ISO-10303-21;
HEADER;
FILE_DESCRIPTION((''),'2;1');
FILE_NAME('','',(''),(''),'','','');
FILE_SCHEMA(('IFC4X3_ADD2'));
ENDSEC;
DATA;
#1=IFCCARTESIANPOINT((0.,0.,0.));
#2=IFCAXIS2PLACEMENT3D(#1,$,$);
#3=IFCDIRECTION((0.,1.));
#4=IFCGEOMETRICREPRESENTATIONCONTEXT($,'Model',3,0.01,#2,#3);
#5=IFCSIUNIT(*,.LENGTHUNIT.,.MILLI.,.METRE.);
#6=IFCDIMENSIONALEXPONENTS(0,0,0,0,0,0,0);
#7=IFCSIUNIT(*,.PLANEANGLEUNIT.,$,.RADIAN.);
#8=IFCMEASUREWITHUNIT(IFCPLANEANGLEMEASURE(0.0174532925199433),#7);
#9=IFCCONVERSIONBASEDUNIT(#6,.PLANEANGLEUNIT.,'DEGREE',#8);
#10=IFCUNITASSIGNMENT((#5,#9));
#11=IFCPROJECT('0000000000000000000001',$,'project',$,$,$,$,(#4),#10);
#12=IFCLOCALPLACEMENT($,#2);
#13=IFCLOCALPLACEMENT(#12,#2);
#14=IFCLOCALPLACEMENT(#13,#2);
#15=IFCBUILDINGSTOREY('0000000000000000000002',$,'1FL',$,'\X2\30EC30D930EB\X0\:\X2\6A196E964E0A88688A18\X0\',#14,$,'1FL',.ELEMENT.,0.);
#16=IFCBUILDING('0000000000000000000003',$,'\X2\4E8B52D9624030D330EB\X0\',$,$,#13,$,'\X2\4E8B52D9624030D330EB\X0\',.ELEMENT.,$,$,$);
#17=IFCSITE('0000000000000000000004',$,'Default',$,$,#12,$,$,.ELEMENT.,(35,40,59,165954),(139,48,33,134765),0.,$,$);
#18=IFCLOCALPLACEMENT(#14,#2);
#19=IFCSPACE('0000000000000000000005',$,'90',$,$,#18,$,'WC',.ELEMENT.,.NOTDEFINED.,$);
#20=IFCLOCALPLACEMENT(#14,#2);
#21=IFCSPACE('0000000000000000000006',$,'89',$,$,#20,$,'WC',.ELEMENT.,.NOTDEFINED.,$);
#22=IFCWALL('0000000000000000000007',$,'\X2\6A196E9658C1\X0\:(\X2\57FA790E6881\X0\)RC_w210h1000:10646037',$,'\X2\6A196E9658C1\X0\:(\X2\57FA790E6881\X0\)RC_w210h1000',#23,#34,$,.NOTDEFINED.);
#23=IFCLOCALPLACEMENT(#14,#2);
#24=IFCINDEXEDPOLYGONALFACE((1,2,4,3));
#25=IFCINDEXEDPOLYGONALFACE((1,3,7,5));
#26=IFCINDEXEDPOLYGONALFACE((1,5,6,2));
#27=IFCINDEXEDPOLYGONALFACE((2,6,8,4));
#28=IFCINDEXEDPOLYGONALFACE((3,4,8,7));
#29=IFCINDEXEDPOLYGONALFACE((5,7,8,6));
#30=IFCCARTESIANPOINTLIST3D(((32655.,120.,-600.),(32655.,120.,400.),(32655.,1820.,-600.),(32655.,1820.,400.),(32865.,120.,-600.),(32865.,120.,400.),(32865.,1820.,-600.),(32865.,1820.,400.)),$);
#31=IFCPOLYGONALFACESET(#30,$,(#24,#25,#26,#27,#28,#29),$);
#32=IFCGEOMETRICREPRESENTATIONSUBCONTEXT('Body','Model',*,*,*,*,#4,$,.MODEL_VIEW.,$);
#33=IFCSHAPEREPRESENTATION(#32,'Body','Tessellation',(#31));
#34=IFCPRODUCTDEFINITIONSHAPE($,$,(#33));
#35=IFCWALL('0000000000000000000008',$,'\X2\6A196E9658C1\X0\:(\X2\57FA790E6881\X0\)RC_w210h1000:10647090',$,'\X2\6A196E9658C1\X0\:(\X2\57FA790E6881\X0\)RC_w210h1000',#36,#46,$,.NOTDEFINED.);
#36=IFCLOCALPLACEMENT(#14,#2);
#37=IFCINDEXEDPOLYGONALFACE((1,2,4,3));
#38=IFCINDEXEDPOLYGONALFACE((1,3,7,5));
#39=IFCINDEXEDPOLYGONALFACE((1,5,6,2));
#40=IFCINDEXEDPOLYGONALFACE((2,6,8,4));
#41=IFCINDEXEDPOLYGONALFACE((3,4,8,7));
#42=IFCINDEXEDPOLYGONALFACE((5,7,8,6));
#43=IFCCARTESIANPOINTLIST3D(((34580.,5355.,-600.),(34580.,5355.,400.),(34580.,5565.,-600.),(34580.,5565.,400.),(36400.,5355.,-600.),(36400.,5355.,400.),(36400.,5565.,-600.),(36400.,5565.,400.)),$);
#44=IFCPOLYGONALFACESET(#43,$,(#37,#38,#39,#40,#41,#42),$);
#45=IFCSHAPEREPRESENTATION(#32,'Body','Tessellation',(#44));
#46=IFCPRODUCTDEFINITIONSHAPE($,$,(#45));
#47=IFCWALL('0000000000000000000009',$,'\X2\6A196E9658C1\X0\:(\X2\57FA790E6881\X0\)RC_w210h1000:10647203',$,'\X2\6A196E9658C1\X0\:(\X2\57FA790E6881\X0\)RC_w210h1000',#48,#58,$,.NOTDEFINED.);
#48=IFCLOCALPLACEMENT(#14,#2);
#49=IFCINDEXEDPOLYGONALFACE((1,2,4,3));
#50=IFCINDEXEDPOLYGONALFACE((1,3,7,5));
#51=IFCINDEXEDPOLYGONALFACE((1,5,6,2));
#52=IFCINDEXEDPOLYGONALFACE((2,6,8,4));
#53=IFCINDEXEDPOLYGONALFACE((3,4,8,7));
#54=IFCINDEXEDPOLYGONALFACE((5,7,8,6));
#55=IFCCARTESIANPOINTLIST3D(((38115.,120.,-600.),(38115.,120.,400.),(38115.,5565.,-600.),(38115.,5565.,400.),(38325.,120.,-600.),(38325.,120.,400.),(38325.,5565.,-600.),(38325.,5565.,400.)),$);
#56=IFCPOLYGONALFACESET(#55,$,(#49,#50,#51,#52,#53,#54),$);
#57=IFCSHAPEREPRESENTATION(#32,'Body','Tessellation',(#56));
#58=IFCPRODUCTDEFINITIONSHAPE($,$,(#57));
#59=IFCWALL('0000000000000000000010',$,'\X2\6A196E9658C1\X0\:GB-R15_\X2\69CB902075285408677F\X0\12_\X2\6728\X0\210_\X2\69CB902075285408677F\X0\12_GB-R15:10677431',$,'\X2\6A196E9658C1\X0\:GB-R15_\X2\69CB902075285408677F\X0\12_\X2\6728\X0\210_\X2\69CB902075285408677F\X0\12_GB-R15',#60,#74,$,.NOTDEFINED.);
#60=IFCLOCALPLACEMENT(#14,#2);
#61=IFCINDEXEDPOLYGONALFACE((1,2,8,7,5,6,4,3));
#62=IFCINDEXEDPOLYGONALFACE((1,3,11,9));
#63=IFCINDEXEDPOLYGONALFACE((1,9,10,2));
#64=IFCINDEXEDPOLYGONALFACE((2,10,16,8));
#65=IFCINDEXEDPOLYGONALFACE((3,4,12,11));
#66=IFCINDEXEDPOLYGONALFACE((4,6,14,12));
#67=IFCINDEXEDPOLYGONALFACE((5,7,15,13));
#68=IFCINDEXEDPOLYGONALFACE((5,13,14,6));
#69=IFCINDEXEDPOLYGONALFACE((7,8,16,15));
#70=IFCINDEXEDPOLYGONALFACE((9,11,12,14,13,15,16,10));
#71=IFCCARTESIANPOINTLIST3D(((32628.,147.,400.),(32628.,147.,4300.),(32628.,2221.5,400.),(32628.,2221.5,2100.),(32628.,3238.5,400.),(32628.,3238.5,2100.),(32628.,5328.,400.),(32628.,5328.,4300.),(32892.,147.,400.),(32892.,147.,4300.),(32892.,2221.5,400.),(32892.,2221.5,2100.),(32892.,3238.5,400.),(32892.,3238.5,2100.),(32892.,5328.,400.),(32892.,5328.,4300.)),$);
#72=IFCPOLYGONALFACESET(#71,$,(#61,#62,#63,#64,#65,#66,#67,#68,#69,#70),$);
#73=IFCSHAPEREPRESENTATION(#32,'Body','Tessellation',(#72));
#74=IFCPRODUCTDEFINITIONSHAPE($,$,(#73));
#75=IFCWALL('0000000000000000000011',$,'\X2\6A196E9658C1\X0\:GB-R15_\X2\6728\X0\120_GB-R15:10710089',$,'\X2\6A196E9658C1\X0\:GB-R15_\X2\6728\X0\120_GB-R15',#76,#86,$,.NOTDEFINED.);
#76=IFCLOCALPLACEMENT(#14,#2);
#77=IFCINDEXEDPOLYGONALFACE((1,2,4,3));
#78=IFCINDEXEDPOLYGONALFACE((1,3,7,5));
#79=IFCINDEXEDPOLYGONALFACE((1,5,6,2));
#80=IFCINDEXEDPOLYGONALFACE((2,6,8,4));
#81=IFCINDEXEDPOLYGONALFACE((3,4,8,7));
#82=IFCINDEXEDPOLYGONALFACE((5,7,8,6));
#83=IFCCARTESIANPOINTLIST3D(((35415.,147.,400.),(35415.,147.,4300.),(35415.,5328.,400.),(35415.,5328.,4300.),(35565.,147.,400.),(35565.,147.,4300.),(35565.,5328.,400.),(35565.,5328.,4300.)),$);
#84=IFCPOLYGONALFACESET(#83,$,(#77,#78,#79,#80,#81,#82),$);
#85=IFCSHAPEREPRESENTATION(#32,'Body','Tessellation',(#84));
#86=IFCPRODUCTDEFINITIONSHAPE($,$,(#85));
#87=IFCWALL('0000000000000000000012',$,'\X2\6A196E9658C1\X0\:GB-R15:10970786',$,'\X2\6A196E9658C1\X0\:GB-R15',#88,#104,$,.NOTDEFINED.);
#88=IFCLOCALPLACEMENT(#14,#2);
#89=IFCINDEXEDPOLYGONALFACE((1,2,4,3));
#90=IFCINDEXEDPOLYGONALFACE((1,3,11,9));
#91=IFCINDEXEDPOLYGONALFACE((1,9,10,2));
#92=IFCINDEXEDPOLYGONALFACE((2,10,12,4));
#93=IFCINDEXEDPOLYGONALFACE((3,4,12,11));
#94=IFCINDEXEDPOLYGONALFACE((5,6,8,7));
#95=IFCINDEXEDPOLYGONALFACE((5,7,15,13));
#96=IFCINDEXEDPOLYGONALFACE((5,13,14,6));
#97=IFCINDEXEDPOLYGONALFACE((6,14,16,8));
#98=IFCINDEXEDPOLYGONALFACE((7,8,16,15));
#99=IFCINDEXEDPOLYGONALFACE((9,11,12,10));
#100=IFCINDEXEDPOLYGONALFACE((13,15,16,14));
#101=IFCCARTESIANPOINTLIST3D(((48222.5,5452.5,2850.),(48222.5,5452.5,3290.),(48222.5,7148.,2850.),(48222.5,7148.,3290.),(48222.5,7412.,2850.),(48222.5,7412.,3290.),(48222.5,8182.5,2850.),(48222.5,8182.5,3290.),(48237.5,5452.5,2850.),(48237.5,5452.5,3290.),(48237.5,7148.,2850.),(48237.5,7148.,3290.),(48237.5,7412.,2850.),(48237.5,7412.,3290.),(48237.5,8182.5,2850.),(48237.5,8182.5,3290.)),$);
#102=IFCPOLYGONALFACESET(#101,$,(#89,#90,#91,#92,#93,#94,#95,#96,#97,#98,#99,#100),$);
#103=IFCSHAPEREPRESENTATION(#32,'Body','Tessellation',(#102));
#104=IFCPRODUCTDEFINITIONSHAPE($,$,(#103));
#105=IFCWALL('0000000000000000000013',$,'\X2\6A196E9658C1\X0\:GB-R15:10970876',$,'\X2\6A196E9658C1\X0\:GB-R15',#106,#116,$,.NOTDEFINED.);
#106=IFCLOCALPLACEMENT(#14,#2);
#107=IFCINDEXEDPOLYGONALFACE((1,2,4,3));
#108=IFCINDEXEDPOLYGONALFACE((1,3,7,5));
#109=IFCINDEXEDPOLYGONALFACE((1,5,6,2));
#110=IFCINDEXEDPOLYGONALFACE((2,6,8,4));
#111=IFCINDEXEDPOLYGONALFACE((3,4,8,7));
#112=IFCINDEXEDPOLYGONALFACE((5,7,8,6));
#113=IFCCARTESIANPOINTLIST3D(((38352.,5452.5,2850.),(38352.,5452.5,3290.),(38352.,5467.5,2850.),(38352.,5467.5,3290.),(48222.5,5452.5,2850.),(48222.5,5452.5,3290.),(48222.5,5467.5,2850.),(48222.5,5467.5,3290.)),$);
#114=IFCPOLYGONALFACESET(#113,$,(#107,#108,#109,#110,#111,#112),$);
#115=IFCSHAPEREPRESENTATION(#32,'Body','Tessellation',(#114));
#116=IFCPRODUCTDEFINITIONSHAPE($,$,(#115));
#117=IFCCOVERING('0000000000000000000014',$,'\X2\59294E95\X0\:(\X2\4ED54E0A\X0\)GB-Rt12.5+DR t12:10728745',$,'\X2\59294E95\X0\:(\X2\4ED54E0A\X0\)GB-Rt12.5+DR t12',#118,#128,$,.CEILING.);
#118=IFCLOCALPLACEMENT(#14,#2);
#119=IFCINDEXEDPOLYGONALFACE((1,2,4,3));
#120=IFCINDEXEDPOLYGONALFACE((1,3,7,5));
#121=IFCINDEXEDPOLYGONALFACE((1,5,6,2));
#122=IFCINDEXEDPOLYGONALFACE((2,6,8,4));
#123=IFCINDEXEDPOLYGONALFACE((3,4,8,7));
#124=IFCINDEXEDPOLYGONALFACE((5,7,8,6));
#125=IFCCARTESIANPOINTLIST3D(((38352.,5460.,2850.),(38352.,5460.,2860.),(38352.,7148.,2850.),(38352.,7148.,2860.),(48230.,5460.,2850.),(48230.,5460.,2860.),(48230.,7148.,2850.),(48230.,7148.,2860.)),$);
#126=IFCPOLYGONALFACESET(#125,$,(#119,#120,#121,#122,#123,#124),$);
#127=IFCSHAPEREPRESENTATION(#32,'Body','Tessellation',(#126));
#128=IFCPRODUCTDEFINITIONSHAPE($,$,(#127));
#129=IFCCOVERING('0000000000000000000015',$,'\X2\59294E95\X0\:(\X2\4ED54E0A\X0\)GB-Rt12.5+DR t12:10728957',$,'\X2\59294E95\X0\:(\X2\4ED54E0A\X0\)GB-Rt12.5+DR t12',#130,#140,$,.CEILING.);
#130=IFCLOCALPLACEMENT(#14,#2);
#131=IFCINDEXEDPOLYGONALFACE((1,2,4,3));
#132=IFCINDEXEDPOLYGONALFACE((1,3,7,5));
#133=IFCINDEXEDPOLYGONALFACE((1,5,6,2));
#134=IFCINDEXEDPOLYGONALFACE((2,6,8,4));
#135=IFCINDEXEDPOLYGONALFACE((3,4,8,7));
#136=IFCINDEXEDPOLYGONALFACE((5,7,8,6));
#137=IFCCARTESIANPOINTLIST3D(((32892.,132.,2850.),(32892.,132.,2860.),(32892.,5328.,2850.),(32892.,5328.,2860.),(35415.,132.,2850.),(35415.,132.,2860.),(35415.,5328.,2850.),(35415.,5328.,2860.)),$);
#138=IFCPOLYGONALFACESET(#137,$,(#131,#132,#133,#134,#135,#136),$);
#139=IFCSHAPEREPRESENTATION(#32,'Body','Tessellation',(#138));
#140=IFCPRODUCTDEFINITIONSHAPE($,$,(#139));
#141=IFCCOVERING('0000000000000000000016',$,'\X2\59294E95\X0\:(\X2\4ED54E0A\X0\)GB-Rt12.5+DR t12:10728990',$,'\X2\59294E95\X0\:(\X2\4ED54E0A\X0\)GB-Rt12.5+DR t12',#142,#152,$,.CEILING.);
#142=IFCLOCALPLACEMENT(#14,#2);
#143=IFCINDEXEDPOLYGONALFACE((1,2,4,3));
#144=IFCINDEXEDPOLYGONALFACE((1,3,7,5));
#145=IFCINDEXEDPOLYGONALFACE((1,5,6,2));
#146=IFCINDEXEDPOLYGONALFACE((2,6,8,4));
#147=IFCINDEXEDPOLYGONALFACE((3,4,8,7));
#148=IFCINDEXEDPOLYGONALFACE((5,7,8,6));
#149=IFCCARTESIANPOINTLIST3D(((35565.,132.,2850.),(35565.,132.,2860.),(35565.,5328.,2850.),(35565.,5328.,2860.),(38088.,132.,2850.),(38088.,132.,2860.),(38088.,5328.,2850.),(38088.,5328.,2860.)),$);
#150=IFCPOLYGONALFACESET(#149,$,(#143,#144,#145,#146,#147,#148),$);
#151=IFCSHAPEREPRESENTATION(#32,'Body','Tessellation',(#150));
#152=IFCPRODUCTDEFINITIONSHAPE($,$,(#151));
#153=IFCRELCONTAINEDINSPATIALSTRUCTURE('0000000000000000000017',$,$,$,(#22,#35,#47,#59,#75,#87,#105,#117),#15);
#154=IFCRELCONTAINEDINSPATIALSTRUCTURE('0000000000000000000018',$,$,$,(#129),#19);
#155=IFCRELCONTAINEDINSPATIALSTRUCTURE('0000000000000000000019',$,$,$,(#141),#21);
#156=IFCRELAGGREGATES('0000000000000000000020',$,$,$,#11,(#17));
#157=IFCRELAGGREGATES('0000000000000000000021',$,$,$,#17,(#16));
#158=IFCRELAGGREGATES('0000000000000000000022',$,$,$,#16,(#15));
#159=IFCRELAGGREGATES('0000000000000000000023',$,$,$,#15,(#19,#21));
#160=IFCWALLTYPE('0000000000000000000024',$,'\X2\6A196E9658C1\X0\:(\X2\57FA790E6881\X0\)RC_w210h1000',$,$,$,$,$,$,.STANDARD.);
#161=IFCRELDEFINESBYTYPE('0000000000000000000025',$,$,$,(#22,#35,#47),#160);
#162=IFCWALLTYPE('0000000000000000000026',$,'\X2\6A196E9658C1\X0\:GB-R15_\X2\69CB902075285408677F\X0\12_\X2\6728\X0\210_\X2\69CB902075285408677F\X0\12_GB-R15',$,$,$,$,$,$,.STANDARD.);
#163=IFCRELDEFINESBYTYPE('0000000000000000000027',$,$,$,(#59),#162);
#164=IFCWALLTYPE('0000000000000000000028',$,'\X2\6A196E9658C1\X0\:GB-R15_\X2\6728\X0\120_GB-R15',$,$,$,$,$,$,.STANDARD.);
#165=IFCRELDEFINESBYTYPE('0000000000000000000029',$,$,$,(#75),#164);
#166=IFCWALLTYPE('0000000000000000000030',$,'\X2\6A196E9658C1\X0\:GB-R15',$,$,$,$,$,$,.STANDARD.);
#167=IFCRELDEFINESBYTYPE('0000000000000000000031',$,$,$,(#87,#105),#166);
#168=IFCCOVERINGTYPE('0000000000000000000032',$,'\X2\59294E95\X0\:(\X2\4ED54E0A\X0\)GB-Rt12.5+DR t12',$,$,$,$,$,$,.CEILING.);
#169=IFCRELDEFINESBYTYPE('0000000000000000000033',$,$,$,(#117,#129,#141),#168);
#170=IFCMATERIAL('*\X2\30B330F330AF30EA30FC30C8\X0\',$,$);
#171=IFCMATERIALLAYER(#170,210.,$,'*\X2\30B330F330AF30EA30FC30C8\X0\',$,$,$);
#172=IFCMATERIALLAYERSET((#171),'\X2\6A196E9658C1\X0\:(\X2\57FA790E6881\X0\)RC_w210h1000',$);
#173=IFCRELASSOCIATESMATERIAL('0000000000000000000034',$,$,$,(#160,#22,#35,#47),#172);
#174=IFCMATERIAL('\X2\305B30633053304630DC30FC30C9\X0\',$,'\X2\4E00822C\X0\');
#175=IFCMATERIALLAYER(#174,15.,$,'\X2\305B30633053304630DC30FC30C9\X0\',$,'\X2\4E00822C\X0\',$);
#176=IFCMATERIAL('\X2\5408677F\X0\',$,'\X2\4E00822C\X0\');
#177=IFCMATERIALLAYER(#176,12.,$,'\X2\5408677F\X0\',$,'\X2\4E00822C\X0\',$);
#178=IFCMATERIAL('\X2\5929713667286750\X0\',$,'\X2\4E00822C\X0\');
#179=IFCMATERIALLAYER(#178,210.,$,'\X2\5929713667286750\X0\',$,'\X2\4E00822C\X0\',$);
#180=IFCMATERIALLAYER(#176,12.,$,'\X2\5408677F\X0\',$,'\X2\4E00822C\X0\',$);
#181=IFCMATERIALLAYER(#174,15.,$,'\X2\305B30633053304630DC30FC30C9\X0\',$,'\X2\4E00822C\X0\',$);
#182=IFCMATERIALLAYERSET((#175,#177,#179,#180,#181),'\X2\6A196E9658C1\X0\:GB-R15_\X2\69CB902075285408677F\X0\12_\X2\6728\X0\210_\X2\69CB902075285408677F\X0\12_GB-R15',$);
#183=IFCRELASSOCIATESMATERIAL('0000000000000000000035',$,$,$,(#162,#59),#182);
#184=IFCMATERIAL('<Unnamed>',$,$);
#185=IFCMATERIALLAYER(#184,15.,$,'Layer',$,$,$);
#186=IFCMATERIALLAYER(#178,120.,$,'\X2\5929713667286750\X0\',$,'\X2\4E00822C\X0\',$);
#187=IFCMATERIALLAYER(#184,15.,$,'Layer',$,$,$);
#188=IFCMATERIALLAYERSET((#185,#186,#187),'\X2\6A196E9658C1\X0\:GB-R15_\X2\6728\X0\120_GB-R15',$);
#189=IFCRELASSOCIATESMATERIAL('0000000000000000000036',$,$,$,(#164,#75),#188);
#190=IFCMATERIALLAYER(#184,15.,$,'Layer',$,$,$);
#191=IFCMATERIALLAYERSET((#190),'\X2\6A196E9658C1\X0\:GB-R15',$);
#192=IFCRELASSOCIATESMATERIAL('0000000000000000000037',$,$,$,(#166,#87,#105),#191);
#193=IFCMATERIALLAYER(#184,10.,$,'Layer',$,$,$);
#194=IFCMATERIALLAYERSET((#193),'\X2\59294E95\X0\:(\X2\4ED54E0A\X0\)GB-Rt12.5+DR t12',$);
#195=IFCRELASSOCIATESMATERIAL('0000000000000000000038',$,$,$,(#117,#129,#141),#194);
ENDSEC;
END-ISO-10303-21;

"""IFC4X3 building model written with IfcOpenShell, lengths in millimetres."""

from ifc_helpers import new_model, entity, si_unit, converted_unit, direction, frame, frame_2d, origin, origin_2d_with_axis, place, context, subcontext, project, spatial, rectangle, extrude, material, layer, layer_set, layer_usage, type_object, element, save


model = new_model("IFC4X3")

# Units and contexts
model_context = context("Model", 3, precision=0.01, world=origin(), true_north=direction((0.0, 1.0)))
body_context = subcontext(model_context, "Body", "Model", "MODEL_VIEW")
ifc_project = project(units=[si_unit("LENGTHUNIT", "METRE", prefix="MILLI"), converted_unit("PLANEANGLEUNIT", "DEGREE", entity("IfcPlaneAngleMeasure", 0.0174532925199433), si_unit("PLANEANGLEUNIT", "RADIAN"), dimensions=[0, 0, 0, 0, 0, 0, 0])], contexts=[model_context])

# Site, building, storey
site_placement = place(None, origin())
site = spatial("IfcSite", under=ifc_project, at=site_placement, Name="Default", CompositionType="ELEMENT", RefLatitude=(35, 40, 59, 165954), RefLongitude=(139, 48, 33, 134765), RefElevation=0.0)
building_placement = place(site_placement, origin())
building = spatial("IfcBuilding", under=site, at=building_placement, Name="事務所ビル", LongName="事務所ビル", CompositionType="ELEMENT")
storey_placement = place(building_placement, origin())
storey = spatial("IfcBuildingStorey", under=building, at=storey_placement, Name="1FL", ObjectType="レベル:標準上表記", LongName="1FL", CompositionType="ELEMENT", Elevation=0.0)

# Shared definitions
ifc_material_1 = material(Name="*コンクリート")

# Walls
ifc_layer_1 = layer(ifc_material_1, 210.0, Name="*コンクリート")
ifc_layer_set_1 = layer_set([ifc_layer_1], Name="標準壁:(基礎梁)RC_w210h1000")
wall_type_1 = type_object("IfcWallType", Name="標準壁:(基礎梁)RC_w210h1000", PredefinedType="STANDARD", material=ifc_layer_set_1)
wall_1_placement = place(storey_placement, frame((32760.0, 120.0, -600.0), z_axis=(0.0, 0.0, 1.0), x_axis=(0.0, 1.0, 0.0)))
element("IfcWall", 1, at=wall_1_placement, inside=storey, type_object=wall_type_1, material=ifc_layer_set_1, Name="標準壁:(基礎梁)RC_w210h1000:10646037", ObjectType="標準壁:(基礎梁)RC_w210h1000", PredefinedType="NOTDEFINED", context=body_context, shape_type="SweptSolid", body=[
    extrude(rectangle(XDim=1700.0, YDim=210.0, at=frame_2d((850.0, 0.0), x_axis=(-1.0, 0.0))), origin(), (0.0, 0.0, 1.0), 1000.0),
])
wall_2_placement = place(storey_placement, frame((34580.0, 5460.0, -600.0)))
element("IfcWall", 2, at=wall_2_placement, inside=storey, type_object=wall_type_1, material=ifc_layer_set_1, Name="標準壁:(基礎梁)RC_w210h1000:10647090", ObjectType="標準壁:(基礎梁)RC_w210h1000", PredefinedType="NOTDEFINED", context=body_context, shape_type="SweptSolid", body=[
    extrude(rectangle(XDim=1820.0, YDim=210.0, at=frame_2d((910.0, 0.0), x_axis=(-1.0, 0.0))), origin(), (0.0, 0.0, 1.0), 1000.0),
])
wall_3_placement = place(storey_placement, frame((38220.0, 120.0, -600.0), z_axis=(0.0, 0.0, 1.0), x_axis=(0.0, 1.0, 0.0)))
element("IfcWall", 3, at=wall_3_placement, inside=storey, type_object=wall_type_1, material=ifc_layer_set_1, Name="標準壁:(基礎梁)RC_w210h1000:10647203", ObjectType="標準壁:(基礎梁)RC_w210h1000", PredefinedType="NOTDEFINED", context=body_context, shape_type="SweptSolid", body=[
    extrude(rectangle(XDim=5445.0, YDim=210.0, at=frame_2d((2722.5, 0.0), x_axis=(-1.0, 0.0))), origin(), (0.0, 0.0, 1.0), 1000.0),
])

# Shared definitions
ifc_material_2 = material(Name="せっこうボード", Category="一般")
ifc_layer_2 = layer(ifc_material_2, 15.0, Name="せっこうボード", Category="一般")
ifc_material_3 = material(Name="合板", Category="一般")
ifc_layer_3 = layer(ifc_material_3, 12.0, Name="合板", Category="一般")
ifc_material_4 = material(Name="天然木材", Category="一般")
ifc_layer_4 = layer(ifc_material_4, 210.0, Name="天然木材", Category="一般")
ifc_layer_5 = layer(ifc_material_3, 12.0, Name="合板", Category="一般")
ifc_layer_6 = layer(ifc_material_2, 15.0, Name="せっこうボード", Category="一般")
ifc_layer_set_2 = layer_set([ifc_layer_2, ifc_layer_3, ifc_layer_4, ifc_layer_5, ifc_layer_6], Name="標準壁:GB-R15_構造用合板12_木210_構造用合板12_GB-R15")
wall_type_2 = type_object("IfcWallType", Name="標準壁:GB-R15_構造用合板12_木210_構造用合板12_GB-R15", PredefinedType="STANDARD", material=ifc_layer_set_2)

# Wall, opening
wall_4_placement = place(storey_placement, frame((32760.0, 147.0, 400.0), z_axis=(0.0, 0.0, 1.0), x_axis=(0.0, 1.0, 0.0)))
wall_4 = element("IfcWall", 4, at=wall_4_placement, inside=storey, type_object=wall_type_2, material=ifc_layer_set_2, Name="標準壁:GB-R15_構造用合板12_木210_構造用合板12_GB-R15:10677431", ObjectType="標準壁:GB-R15_構造用合板12_木210_構造用合板12_GB-R15", PredefinedType="NOTDEFINED", context=body_context, shape_type="SweptSolid", body=[
    extrude(rectangle(XDim=5181.0, YDim=264.0, at=frame_2d((2590.5, 0.0), x_axis=(1.0, 0.0))), origin(), (0.0, 0.0, 1.0), 3900.0),
])
opening_1_placement = place(wall_4_placement, frame((2074.5, -132.0, -400.0)))
element("IfcOpeningElement", 5, at=opening_1_placement, cuts=wall_4, PredefinedType="OPENING", context=body_context, shape_type="SweptSolid", body=[
    extrude(rectangle(XDim=2100.0, YDim=1017.0, at=frame_2d((1050.0, 508.5), x_axis=(-1.0, 0.0))), frame((0.0, 0.0, 0.0), z_axis=(0.0, 1.0, 0.0), x_axis=(0.0, 0.0, 1.0)), (0.0, 0.0, 1.0), 264.0),
])

# Wall
ifc_material_5 = material(Name="<Unnamed>")
ifc_layer_7 = layer(ifc_material_5, 15.0, Name="Layer")
ifc_layer_8 = layer(ifc_material_4, 120.0, Name="天然木材", Category="一般")
ifc_layer_9 = layer(ifc_material_5, 15.0, Name="Layer")
ifc_layer_set_3 = layer_set([ifc_layer_7, ifc_layer_8, ifc_layer_9], Name="標準壁:GB-R15_木120_GB-R15")
wall_type_3 = type_object("IfcWallType", Name="標準壁:GB-R15_木120_GB-R15", PredefinedType="STANDARD", material=ifc_layer_set_3)
wall_5_placement = place(storey_placement, frame((35490.0, 147.0, 400.0), z_axis=(0.0, 0.0, 1.0), x_axis=(0.0, 1.0, 0.0)))
element("IfcWall", 6, at=wall_5_placement, inside=storey, type_object=wall_type_3, material=ifc_layer_set_3, Name="標準壁:GB-R15_木120_GB-R15:10710089", ObjectType="標準壁:GB-R15_木120_GB-R15", PredefinedType="NOTDEFINED", context=body_context, shape_type="SweptSolid", body=[
    extrude(rectangle(XDim=5181.0, YDim=150.0, at=frame_2d((2590.5, 0.0), x_axis=(-1.0, 0.0))), origin(), (0.0, 0.0, 1.0), 3900.0),
])

# Wall, opening
ifc_layer_10 = layer(ifc_material_5, 15.0, Name="Layer")
ifc_layer_set_4 = layer_set([ifc_layer_10], Name="標準壁:GB-R15")
wall_type_4 = type_object("IfcWallType", Name="標準壁:GB-R15", PredefinedType="STANDARD", material=ifc_layer_set_4)
wall_6_placement = place(storey_placement, frame((48230.0, 8182.5, 2850.0), z_axis=(0.0, 0.0, 1.0), x_axis=(0.0, -1.0, 0.0)))
wall_6 = element("IfcWall", 7, at=wall_6_placement, inside=storey, type_object=wall_type_4, material=ifc_layer_set_4, Name="標準壁:GB-R15:10970786", ObjectType="標準壁:GB-R15", PredefinedType="NOTDEFINED", context=body_context, shape_type="SweptSolid", body=[
    extrude(rectangle(XDim=2730.0, YDim=15.0, at=frame_2d((1365.0, 0.0), x_axis=(-1.0, 0.0))), origin(), (0.0, 0.0, 1.0), 440.0),
])
opening_2_placement = place(storey_placement, frame((48230.0, 8182.5, 2850.0), z_axis=(0.0, 0.0, 1.0), x_axis=(0.0, -1.0, 0.0)))
element("IfcOpeningElement", 8, at=opening_2_placement, cuts=wall_6, PredefinedType="OPENING", context=body_context, shape_type="SweptSolid", body=[
    extrude(rectangle(XDim=440.0, YDim=15.0, at=frame_2d((0.0, 0.0), x_axis=(1.0, 0.0))), frame((1034.5, 0.0, 220.0), z_axis=(-1.0, 0.0, 0.0), x_axis=(0.0, 0.0, 1.0)), (0.0, 0.0, 1.0), 264.0),
])

# Wall
wall_7_placement = place(storey_placement, frame((48222.5, 5460.0, 2850.0), z_axis=(0.0, 0.0, 1.0), x_axis=(-1.0, 0.0, 0.0)))
element("IfcWall", 9, at=wall_7_placement, inside=storey, type_object=wall_type_4, material=ifc_layer_set_4, Name="標準壁:GB-R15:10970876", ObjectType="標準壁:GB-R15", PredefinedType="NOTDEFINED", context=body_context, shape_type="SweptSolid", body=[
    extrude(rectangle(XDim=9870.5, YDim=15.0, at=frame_2d((4935.2, 0.0), x_axis=(-1.0, 0.0))), origin(), (0.0, 0.0, 1.0), 440.0),
])

# Covering
ifc_layer_11 = layer(ifc_material_5, 10.0, Name="Layer")
ifc_layer_set_5 = layer_set([ifc_layer_11], Name="天井:(仕上)GB-Rt12.5+DR t12")
covering_type = type_object("IfcCoveringType", Name="天井:(仕上)GB-Rt12.5+DR t12", PredefinedType="CEILING")
ifc_layer_usage_1 = layer_usage(ifc_layer_set_5, "AXIS3", "NEGATIVE", 0.0)
covering_1_placement = place(storey_placement, frame((38352.0, 5460.0, 2850.0)))
element("IfcCovering", 10, at=covering_1_placement, inside=storey, type_object=covering_type, material=ifc_layer_usage_1, Name="天井:(仕上)GB-Rt12.5+DR t12:10728745", ObjectType="天井:(仕上)GB-Rt12.5+DR t12", PredefinedType="CEILING", context=body_context, shape_type="SweptSolid", body=[
    extrude(rectangle(XDim=9878.0, YDim=1688.0, at=origin_2d_with_axis()), frame((4939.0, 844.0, 0.0)), (0.0, 0.0, 1.0), 10.0),
])

# Shared definitions
space_1_placement = place(storey_placement, origin())
space_1 = spatial("IfcSpace", under=storey, at=space_1_placement, Name="90", LongName="WC", CompositionType="ELEMENT", PredefinedType="NOTDEFINED")

# Covering
ifc_layer_usage_2 = layer_usage(ifc_layer_set_5, "AXIS3", "NEGATIVE", 0.0)
covering_2_placement = place(space_1_placement, frame((32892.0, 132.0, 2850.0)))
element("IfcCovering", 11, at=covering_2_placement, inside=space_1, type_object=covering_type, material=ifc_layer_usage_2, Name="天井:(仕上)GB-Rt12.5+DR t12:10728957", ObjectType="天井:(仕上)GB-Rt12.5+DR t12", PredefinedType="CEILING", context=body_context, shape_type="SweptSolid", body=[
    extrude(rectangle(XDim=2523.0, YDim=5196.0, at=frame_2d((0.0, 0.0), x_axis=(1.0, 0.0))), frame((1261.5, 2598.0, 0.0), z_axis=(0.0, 0.0, 1.0), x_axis=(-1.0, 0.0, 0.0)), (0.0, 0.0, 1.0), 10.0),
])

# Shared definitions
space_2_placement = place(storey_placement, origin())
space_2 = spatial("IfcSpace", under=storey, at=space_2_placement, Name="89", LongName="WC", CompositionType="ELEMENT", PredefinedType="NOTDEFINED")

# Covering
ifc_layer_usage_3 = layer_usage(ifc_layer_set_5, "AXIS3", "NEGATIVE", 0.0)
covering_3_placement = place(space_2_placement, frame((35565.0, 132.0, 2850.0)))
element("IfcCovering", 12, at=covering_3_placement, inside=space_2, type_object=covering_type, material=ifc_layer_usage_3, Name="天井:(仕上)GB-Rt12.5+DR t12:10728990", ObjectType="天井:(仕上)GB-Rt12.5+DR t12", PredefinedType="CEILING", context=body_context, shape_type="SweptSolid", body=[
    extrude(rectangle(XDim=2523.0, YDim=5196.0, at=frame_2d((0.0, 0.0), x_axis=(1.0, 0.0))), frame((1261.5, 2598.0, 0.0), z_axis=(0.0, 0.0, 1.0), x_axis=(-1.0, 0.0, 0.0)), (0.0, 0.0, 1.0), 10.0),
])

save(model, "model.ifc")
